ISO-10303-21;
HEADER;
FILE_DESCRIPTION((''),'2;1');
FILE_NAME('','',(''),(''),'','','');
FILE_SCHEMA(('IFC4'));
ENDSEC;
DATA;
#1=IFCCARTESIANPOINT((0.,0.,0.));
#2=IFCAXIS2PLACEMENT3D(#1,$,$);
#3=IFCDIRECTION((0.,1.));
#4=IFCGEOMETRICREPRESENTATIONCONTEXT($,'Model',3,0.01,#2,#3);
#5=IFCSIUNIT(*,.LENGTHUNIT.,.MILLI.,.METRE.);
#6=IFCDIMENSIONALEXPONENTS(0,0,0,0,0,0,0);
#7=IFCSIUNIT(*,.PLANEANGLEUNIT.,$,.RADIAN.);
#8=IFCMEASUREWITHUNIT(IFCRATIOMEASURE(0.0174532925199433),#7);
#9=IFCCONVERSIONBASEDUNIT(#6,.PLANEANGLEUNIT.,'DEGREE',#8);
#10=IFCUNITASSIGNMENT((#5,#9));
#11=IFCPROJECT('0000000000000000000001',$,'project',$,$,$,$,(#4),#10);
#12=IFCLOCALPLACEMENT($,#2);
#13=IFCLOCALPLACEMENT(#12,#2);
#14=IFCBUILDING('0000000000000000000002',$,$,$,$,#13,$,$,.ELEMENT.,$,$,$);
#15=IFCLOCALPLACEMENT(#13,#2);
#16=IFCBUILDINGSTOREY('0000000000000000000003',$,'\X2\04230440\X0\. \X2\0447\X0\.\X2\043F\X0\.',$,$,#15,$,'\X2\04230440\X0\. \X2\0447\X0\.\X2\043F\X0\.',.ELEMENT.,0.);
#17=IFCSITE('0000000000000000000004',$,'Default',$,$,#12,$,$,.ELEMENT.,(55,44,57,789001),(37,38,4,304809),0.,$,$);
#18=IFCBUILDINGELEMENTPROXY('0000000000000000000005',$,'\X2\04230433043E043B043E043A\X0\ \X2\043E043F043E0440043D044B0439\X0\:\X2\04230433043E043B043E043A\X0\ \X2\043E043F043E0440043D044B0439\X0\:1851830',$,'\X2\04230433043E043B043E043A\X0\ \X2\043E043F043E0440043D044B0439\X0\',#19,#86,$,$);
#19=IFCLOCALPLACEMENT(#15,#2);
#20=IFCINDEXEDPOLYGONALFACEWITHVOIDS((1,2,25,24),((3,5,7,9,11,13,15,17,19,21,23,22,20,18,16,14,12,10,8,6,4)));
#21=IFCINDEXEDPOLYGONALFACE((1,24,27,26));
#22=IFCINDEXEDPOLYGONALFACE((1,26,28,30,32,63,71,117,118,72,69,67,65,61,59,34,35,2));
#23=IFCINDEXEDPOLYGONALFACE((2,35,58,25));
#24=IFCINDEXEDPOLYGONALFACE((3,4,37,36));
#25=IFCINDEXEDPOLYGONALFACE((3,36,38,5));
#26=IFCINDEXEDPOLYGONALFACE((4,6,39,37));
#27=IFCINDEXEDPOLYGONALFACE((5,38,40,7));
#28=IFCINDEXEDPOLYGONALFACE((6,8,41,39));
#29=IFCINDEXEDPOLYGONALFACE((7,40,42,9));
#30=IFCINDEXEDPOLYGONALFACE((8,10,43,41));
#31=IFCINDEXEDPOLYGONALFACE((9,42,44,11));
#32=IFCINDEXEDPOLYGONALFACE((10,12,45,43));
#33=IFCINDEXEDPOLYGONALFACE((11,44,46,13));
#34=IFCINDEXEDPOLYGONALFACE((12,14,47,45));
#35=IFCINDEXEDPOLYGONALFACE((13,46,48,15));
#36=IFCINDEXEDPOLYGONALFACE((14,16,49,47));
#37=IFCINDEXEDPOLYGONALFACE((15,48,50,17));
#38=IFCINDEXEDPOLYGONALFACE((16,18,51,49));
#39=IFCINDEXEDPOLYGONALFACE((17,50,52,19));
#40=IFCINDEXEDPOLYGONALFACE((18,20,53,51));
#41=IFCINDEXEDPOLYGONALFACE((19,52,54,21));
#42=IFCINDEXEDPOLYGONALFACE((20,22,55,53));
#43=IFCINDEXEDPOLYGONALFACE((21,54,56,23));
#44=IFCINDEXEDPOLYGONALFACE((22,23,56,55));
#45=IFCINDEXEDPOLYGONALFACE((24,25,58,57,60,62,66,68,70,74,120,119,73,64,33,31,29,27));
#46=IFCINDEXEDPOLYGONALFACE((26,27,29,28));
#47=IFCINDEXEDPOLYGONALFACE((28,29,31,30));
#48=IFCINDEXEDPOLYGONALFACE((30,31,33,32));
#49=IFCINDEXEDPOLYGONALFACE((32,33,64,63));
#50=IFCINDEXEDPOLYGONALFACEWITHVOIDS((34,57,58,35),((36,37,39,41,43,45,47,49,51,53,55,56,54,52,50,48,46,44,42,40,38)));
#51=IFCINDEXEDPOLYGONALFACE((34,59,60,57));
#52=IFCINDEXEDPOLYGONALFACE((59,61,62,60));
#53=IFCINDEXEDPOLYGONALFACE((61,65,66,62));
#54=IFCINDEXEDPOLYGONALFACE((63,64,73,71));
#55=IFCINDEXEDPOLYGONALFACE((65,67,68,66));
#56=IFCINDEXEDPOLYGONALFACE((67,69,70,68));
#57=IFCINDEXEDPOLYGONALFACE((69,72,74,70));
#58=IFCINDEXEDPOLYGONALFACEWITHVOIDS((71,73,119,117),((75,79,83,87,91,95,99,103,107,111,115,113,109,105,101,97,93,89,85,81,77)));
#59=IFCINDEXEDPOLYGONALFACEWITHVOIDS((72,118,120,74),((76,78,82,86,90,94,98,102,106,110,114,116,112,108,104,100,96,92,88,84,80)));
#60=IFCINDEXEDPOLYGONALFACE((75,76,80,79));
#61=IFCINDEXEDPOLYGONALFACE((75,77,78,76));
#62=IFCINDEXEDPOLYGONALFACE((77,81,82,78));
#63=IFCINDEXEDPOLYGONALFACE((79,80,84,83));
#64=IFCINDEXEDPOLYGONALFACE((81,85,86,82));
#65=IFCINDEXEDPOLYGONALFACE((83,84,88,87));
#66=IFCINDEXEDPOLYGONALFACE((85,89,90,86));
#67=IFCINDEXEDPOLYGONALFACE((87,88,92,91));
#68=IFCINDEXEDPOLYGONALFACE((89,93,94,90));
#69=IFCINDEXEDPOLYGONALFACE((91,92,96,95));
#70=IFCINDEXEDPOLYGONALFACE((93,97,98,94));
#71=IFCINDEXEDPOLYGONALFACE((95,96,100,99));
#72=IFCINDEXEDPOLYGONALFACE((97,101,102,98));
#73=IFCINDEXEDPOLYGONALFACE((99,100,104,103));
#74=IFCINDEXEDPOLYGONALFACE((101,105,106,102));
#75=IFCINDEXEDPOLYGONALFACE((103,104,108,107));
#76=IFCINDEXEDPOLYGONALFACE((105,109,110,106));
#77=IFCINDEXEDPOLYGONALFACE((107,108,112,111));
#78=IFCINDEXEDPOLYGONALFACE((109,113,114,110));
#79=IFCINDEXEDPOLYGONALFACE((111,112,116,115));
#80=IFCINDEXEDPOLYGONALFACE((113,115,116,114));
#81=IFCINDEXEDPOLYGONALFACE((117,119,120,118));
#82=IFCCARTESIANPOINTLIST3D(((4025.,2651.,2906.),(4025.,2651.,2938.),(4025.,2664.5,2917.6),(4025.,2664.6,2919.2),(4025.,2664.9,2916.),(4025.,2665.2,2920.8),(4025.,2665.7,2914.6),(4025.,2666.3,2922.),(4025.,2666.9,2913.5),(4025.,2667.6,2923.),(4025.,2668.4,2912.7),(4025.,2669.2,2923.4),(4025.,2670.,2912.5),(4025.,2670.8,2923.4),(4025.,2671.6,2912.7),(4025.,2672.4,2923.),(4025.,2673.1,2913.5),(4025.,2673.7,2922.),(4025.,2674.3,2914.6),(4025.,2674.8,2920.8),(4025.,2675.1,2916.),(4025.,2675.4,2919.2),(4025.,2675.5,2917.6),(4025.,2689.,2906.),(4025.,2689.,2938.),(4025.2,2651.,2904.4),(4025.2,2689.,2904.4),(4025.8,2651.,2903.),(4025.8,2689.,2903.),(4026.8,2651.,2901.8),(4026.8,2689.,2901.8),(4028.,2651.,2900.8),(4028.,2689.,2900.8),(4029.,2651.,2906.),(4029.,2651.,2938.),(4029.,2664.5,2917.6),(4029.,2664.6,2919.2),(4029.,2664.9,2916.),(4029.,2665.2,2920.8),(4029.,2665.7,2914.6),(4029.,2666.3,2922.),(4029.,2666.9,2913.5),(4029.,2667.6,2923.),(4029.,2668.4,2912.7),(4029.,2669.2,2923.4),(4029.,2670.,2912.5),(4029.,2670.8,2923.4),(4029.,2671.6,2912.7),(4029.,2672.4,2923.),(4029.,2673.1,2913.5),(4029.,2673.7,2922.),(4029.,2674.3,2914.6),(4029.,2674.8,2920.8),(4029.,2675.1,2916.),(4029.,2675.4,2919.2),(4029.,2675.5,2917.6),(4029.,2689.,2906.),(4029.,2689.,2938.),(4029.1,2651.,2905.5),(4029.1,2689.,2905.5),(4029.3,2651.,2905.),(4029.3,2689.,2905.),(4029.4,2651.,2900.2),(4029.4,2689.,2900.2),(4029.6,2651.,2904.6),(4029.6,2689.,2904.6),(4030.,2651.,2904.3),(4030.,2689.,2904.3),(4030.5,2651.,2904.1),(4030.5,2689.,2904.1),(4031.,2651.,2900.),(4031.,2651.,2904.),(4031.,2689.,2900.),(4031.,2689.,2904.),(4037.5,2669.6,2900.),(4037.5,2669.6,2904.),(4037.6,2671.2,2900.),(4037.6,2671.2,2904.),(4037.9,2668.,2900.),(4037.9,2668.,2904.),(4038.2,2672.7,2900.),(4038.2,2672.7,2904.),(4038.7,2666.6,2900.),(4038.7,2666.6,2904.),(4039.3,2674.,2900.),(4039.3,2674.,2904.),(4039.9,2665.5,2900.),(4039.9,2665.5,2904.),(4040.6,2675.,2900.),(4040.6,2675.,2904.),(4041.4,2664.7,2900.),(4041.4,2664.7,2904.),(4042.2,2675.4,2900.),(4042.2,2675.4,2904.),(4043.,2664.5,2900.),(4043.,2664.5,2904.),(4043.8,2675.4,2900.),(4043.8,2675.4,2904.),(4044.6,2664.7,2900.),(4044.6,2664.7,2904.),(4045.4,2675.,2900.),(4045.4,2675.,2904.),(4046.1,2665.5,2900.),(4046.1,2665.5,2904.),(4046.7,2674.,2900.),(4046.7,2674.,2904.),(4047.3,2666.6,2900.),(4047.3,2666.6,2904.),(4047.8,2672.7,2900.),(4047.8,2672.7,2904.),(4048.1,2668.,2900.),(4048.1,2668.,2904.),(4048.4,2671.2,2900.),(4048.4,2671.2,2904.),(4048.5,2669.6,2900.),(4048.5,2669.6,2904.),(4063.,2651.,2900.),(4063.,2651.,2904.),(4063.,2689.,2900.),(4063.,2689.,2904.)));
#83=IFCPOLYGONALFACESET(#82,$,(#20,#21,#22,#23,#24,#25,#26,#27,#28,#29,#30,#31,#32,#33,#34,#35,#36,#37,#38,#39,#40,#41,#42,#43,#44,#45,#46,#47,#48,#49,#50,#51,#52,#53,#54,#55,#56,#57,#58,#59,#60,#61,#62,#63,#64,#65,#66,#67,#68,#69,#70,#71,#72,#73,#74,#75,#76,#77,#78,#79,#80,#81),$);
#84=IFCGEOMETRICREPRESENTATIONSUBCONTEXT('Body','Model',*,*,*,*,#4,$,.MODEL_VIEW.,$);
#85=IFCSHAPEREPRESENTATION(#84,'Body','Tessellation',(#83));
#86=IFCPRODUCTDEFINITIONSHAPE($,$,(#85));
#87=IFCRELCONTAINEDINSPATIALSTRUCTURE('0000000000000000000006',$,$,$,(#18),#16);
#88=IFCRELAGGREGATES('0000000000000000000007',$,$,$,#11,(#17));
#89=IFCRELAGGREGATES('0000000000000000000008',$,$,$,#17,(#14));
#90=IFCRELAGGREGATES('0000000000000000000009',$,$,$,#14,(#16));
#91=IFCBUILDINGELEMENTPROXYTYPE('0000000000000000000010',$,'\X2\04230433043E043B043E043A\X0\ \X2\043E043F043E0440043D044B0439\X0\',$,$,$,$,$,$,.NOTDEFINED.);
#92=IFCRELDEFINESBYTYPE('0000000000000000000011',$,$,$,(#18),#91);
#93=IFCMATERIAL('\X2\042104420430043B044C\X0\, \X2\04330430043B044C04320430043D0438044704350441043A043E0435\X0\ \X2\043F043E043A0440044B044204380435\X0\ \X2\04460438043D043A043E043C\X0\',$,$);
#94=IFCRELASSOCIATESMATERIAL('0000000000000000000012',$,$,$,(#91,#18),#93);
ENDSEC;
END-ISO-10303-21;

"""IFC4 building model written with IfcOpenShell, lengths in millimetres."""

from ifc_helpers import new_model, entity, si_unit, converted_unit, direction, frame, frame_2d, origin, place, context, subcontext, project, spatial, polyline, circle_curve, parameter, trimmed, segment, composite_curve, circle, outline, extrude, source, transform, mapped, material, type_object, type_shapes, element, save


model = new_model("IFC4")

# Units and contexts
model_context = context("Model", 3, precision=0.01, world=origin(), true_north=direction((0.0, 1.0)))
body_context = subcontext(model_context, "Body", "Model", "MODEL_VIEW")
ifc_project = project(units=[si_unit("LENGTHUNIT", "METRE", prefix="MILLI"), converted_unit("PLANEANGLEUNIT", "DEGREE", entity("IfcRatioMeasure", 0.0174532925199433), si_unit("PLANEANGLEUNIT", "RADIAN"), dimensions=[0, 0, 0, 0, 0, 0, 0])], contexts=[model_context])

# Site, building, storey
site_placement = place(None, origin())
site = spatial("IfcSite", under=ifc_project, at=site_placement, Name="Default", CompositionType="ELEMENT", RefLatitude=(55, 44, 57, 789001), RefLongitude=(37, 38, 4, 304809), RefElevation=0.0)
building_placement = place(site_placement, origin())
building = spatial("IfcBuilding", under=site, at=building_placement, CompositionType="ELEMENT")
storey_placement = place(building_placement, origin())
storey = spatial("IfcBuildingStorey", under=building, at=storey_placement, Name="Ур. ч.п.", LongName="Ур. ч.п.", CompositionType="ELEMENT", Elevation=0.0)

# Building element proxy, openings
ifc_material = material(Name="Сталь, гальваническое покрытие цинком")
building_element_proxy_type_1 = type_object("IfcBuildingElementProxyType", Name="Уголок опорный", material=ifc_material)
shared_shape_1 = source(origin(), body_context, "Body", "SweptSolid", [
    extrude(outline(composite_curve([segment(polyline([(-6.0, -12.0), (26.0, -12.0)]), True, "CONTINUOUS"), segment(polyline([(26.0, -12.0), (26.0, -8.0)]), True, "CONTINUOUS"), segment(polyline([(26.0, -8.0), (-6.0, -8.0)]), True, "CONTINUOUS"), segment(trimmed(circle_curve(frame_2d((-6.0, -6.0), x_axis=(0.0, -1.0)), 2.0), [parameter(270.0)], [parameter(0.0)], True, "PARAMETER"), False, "CONTINUOUS"), segment(polyline([(-8.0, -6.0), (-8.0, 26.0)]), True, "CONTINUOUS"), segment(polyline([(-8.0, 26.0), (-12.0, 26.0)]), True, "CONTINUOUS"), segment(polyline([(-12.0, 26.0), (-12.0, -6.0)]), True, "CONTINUOUS"), segment(trimmed(circle_curve(frame_2d((-6.0, -6.0), x_axis=(0.0, -1.0)), 6.0), [parameter(270.0)], [parameter(360.0)], True, "PARAMETER"), True, "CONTINUOUS")], self_intersect=False)), frame((12.0, -19.0, 12.0), z_axis=(0.0, 1.0, 0.0), x_axis=(0.0, 0.0, 1.0)), (0.0, 0.0, 1.0), 38.0),
])
type_shapes(building_element_proxy_type_1, [shared_shape_1])
proxy_1_placement = place(storey_placement, frame((4025.0, 2670.0, 2900.0)))
proxy_1 = element("IfcBuildingElementProxy", 1, at=proxy_1_placement, inside=storey, type_object=building_element_proxy_type_1, material=ifc_material, Name="Уголок опорный:Уголок опорный:1851830", ObjectType="Уголок опорный", context=body_context, shape_type="MappedRepresentation", body=[
    mapped(shared_shape_1, transform((0.0, 0.0, 0.0), scale=1.0)),
])
opening_1_placement = place(storey_placement, frame((4025.0, 2670.0, 2900.0)))
element("IfcOpeningElement", 2, at=opening_1_placement, cuts=proxy_1, ObjectType="Opening", PredefinedType="OPENING", context=body_context, shape_type="SweptSolid", body=[
    extrude(circle(Radius=5.5, at=frame_2d((0.0, 0.0), x_axis=(1.0, 0.0))), frame((4.0, 0.0, 18.0), z_axis=(-1.0, 0.0, 0.0), x_axis=(0.0, 0.0, -1.0)), (0.0, 0.0, 1.0), 4.0),
])
opening_2_placement = place(storey_placement, frame((4025.0, 2670.0, 2900.0)))
element("IfcOpeningElement", 3, at=opening_2_placement, cuts=proxy_1, ObjectType="Opening", PredefinedType="OPENING", context=body_context, shape_type="SweptSolid", body=[
    extrude(circle(Radius=5.5, at=frame_2d((0.0, 0.0), x_axis=(1.0, 0.0))), frame((18.0, 0.0, 0.0), z_axis=(0.0, 0.0, 1.0), x_axis=(0.0, -1.0, 0.0)), (0.0, 0.0, 1.0), 4.0),
])

save(model, "model.ifc")
